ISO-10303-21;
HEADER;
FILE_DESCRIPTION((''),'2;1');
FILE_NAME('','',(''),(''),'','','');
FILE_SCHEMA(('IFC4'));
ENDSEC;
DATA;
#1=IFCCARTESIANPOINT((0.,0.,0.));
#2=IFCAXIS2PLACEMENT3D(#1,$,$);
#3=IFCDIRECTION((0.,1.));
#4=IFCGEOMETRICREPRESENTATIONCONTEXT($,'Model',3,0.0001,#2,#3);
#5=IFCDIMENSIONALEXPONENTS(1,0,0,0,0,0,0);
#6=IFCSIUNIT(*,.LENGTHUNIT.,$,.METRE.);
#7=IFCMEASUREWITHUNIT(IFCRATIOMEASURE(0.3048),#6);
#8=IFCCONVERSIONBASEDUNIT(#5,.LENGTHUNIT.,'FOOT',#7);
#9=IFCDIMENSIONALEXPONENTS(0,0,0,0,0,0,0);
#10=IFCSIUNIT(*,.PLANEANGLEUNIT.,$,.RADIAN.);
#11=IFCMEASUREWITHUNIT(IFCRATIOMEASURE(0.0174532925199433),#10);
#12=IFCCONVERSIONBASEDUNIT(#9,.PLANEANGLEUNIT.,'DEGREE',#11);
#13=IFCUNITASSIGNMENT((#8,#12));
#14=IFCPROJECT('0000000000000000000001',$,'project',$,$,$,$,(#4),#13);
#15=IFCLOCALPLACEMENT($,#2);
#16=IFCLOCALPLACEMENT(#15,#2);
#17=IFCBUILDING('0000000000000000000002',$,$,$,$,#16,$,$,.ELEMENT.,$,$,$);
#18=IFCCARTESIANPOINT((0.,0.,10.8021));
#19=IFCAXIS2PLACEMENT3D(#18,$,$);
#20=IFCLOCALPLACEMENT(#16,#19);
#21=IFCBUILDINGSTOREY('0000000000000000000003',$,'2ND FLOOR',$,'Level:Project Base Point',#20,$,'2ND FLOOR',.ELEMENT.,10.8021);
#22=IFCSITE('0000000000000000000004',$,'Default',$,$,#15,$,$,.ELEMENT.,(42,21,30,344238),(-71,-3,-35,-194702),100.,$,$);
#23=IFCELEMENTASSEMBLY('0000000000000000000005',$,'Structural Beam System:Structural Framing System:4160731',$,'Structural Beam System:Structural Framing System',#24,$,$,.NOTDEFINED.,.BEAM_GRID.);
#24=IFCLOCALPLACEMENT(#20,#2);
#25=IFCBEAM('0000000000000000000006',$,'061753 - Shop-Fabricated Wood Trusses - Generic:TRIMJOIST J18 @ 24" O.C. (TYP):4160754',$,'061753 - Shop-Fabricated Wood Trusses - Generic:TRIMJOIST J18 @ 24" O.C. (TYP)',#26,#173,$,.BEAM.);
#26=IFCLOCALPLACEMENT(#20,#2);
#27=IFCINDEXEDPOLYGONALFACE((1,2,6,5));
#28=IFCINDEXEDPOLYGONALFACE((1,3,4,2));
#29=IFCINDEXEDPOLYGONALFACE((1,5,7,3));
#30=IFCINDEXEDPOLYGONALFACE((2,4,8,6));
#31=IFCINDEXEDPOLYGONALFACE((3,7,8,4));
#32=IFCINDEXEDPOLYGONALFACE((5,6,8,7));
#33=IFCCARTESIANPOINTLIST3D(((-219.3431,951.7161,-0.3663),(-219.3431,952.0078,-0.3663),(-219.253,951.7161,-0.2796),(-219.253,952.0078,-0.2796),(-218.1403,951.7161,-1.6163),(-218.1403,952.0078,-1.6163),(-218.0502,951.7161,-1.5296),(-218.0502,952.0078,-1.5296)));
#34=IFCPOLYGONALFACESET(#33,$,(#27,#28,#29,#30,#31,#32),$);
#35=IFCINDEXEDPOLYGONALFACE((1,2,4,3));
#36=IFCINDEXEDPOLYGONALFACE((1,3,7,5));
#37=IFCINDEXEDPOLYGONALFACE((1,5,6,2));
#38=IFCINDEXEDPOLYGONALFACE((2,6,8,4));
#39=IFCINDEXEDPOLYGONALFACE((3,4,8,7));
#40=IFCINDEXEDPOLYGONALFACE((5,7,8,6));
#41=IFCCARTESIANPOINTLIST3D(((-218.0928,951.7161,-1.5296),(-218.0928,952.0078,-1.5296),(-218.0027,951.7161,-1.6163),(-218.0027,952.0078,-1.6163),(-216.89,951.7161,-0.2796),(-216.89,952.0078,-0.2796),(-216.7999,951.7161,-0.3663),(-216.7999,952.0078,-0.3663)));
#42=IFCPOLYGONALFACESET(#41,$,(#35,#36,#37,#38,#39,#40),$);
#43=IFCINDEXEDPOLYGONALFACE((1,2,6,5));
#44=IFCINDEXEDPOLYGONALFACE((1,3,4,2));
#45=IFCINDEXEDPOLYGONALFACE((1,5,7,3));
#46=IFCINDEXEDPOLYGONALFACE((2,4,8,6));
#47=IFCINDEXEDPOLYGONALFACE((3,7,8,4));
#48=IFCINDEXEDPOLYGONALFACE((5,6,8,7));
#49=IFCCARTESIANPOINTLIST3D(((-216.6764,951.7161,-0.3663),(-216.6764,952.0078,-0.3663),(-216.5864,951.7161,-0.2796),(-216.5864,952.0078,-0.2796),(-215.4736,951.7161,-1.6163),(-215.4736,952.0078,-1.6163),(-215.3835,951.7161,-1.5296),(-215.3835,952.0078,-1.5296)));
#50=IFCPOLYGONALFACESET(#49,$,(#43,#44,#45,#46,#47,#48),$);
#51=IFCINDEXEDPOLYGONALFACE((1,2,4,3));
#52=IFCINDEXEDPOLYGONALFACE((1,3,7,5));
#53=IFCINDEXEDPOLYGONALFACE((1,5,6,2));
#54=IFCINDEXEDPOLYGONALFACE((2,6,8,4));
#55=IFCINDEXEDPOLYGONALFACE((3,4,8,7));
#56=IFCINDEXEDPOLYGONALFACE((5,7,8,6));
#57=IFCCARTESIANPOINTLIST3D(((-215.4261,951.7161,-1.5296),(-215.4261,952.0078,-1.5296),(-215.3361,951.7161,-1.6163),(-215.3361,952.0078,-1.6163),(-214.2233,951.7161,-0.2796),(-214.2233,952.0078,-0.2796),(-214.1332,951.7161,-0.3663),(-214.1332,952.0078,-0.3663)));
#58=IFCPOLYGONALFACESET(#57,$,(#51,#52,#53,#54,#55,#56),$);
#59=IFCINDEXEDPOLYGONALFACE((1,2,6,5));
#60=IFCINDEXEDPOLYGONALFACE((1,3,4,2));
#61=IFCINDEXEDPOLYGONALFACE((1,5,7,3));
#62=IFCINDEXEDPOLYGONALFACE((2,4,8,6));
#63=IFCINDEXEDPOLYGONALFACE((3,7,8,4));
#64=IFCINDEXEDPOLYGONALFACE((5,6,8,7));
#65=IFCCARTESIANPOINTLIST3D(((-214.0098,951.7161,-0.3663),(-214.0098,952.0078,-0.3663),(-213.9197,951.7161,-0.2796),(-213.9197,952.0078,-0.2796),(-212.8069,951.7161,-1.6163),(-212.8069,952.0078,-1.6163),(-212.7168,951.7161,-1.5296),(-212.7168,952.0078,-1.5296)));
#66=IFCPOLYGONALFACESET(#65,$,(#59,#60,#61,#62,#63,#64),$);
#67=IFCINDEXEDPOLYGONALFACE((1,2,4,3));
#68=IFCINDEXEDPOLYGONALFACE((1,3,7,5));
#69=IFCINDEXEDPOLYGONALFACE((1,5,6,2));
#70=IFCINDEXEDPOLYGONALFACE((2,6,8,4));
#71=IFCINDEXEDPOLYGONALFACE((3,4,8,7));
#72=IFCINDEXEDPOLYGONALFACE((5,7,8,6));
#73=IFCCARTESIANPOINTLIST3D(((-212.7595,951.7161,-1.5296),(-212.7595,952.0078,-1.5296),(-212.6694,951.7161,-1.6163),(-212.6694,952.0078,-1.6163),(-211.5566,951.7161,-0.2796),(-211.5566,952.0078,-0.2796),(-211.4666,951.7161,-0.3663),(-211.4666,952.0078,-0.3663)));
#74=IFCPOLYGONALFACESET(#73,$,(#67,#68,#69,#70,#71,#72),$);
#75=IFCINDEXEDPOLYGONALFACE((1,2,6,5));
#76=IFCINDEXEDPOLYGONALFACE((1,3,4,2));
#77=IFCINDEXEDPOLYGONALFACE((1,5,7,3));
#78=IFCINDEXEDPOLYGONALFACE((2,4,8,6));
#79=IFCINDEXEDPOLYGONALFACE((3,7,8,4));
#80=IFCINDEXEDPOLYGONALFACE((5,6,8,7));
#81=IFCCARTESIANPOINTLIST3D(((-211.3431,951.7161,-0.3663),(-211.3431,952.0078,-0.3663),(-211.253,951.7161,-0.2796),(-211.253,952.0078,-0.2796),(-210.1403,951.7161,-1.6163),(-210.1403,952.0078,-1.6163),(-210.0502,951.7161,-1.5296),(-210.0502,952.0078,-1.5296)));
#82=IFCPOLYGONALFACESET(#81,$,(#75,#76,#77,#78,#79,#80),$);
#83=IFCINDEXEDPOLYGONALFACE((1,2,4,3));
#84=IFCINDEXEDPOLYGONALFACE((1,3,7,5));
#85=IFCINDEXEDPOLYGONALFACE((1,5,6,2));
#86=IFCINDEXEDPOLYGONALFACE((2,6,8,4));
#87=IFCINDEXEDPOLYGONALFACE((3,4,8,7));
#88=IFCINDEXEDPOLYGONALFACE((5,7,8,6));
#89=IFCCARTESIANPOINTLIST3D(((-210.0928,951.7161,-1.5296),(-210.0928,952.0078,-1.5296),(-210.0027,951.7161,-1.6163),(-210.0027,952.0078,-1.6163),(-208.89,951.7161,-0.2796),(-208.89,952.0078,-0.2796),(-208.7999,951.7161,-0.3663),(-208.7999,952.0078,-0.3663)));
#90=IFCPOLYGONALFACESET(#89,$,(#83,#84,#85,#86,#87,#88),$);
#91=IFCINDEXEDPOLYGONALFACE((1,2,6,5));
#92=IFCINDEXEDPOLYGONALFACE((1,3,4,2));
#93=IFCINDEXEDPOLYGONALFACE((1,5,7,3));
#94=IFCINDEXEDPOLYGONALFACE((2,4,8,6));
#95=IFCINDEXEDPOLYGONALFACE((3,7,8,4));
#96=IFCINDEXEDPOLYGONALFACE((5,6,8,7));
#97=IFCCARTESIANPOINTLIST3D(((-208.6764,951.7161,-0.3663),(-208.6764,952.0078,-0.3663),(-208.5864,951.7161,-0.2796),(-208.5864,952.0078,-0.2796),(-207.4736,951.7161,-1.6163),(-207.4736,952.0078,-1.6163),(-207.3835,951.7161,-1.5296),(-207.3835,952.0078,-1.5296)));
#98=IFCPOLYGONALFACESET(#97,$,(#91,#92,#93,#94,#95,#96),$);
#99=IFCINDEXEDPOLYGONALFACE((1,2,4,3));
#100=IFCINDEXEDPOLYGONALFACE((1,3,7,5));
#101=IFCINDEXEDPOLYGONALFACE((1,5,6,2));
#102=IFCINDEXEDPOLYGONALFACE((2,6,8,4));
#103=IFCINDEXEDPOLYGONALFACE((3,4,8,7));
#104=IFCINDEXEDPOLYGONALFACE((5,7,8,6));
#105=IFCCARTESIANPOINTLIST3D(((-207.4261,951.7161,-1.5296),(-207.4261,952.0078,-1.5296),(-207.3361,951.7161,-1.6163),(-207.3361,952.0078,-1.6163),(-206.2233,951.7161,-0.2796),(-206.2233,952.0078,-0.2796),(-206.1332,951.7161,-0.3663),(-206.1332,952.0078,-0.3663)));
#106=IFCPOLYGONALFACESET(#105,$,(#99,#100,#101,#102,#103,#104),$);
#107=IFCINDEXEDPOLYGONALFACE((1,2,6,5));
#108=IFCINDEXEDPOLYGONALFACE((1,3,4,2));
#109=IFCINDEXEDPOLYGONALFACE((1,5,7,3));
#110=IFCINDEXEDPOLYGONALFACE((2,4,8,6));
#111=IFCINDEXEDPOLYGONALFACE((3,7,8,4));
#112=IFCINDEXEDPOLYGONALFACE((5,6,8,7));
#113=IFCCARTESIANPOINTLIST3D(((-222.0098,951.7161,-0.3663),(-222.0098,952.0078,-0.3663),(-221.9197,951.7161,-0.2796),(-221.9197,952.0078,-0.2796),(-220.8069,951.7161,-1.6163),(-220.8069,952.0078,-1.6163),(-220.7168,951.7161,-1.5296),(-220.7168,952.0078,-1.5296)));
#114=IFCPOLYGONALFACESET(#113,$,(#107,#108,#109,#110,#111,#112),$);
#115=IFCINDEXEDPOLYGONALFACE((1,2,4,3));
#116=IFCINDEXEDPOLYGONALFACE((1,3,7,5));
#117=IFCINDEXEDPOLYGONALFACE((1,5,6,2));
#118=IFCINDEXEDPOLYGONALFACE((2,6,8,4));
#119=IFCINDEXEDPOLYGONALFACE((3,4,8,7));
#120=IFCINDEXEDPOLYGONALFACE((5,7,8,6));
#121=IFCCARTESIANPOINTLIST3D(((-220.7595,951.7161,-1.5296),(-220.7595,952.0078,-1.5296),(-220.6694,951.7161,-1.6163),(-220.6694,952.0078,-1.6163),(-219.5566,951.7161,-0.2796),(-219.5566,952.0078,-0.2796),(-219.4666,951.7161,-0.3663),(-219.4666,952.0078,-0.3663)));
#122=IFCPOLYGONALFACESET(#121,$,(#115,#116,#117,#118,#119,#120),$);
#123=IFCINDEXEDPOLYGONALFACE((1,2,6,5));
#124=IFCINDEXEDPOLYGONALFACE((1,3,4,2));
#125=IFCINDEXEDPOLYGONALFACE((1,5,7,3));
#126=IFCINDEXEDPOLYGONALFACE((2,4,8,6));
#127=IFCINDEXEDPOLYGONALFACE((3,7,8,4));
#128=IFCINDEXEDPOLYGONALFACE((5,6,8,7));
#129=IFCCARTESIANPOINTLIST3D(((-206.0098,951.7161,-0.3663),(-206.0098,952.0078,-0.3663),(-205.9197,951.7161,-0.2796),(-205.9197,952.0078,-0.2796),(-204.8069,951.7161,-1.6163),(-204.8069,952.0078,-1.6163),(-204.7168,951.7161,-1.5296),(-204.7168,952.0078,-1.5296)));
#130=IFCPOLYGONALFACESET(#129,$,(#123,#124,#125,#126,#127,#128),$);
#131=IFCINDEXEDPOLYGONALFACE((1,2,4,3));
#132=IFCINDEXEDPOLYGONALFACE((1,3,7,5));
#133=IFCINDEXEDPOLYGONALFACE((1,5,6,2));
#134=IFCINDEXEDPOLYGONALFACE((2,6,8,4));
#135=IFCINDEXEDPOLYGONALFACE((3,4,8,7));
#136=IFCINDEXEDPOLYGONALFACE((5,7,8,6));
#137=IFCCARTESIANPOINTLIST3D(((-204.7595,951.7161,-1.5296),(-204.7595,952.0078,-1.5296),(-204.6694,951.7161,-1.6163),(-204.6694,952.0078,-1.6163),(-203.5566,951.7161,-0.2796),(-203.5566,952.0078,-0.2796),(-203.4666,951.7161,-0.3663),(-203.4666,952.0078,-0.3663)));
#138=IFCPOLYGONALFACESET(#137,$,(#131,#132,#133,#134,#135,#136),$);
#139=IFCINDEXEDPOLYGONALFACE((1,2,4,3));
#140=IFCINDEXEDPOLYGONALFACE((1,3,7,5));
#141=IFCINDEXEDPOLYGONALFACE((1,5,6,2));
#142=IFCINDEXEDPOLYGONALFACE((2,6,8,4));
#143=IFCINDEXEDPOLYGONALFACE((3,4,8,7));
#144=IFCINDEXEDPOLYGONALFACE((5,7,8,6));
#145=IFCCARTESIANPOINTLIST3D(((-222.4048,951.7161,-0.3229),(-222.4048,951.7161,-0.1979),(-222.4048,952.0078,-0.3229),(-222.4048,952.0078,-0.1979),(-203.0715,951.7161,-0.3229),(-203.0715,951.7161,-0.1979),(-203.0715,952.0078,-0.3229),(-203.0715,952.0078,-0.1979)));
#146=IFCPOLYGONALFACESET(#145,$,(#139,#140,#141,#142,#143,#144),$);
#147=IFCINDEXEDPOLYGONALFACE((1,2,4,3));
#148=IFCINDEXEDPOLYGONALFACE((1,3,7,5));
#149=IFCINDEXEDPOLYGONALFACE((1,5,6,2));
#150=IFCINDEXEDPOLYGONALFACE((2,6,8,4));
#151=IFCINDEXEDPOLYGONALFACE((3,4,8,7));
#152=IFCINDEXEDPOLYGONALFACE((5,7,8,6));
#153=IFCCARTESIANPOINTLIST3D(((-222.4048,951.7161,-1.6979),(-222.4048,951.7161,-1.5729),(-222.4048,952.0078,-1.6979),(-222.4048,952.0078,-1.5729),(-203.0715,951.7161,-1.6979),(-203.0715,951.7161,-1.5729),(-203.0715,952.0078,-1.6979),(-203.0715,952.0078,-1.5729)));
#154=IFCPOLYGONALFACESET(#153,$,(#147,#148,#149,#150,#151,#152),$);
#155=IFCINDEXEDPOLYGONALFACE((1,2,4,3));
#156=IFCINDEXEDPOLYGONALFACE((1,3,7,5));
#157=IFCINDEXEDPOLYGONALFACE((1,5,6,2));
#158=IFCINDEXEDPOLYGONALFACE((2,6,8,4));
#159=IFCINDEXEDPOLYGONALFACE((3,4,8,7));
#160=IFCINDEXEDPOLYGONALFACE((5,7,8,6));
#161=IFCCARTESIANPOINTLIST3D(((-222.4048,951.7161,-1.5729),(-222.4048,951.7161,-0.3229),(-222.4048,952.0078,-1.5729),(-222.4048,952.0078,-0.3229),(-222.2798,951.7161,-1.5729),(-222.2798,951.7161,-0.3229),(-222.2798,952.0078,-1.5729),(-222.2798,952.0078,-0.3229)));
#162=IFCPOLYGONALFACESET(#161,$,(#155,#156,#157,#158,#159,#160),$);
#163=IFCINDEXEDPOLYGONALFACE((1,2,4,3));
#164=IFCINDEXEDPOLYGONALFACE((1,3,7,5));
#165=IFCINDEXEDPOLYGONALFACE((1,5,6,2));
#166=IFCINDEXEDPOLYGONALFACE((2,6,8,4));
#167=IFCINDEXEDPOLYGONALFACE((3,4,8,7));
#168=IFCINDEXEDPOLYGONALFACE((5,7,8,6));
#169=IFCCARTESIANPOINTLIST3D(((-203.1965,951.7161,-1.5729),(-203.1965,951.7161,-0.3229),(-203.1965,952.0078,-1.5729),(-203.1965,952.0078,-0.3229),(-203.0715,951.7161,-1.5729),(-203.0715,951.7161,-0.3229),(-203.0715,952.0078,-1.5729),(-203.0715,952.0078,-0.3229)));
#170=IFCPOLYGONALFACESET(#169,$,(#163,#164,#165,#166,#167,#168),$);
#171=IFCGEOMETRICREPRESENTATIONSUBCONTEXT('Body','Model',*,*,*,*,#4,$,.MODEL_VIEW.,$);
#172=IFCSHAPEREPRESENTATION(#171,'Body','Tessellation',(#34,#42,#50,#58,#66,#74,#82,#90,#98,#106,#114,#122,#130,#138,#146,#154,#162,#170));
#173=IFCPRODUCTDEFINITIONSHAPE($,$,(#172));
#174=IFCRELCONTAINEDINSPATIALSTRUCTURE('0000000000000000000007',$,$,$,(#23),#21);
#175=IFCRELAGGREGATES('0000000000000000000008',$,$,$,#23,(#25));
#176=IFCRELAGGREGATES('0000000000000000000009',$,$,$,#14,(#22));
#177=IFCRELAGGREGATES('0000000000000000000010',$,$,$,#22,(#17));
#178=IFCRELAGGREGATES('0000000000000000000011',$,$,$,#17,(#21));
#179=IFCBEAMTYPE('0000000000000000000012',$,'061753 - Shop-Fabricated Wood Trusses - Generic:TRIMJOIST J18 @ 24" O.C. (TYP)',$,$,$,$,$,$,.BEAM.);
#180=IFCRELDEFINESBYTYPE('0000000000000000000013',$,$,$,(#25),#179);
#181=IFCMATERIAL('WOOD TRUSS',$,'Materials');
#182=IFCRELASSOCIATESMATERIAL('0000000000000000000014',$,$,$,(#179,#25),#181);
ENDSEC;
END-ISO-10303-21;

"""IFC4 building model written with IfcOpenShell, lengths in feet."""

from ifc_helpers import new_model, entity, si_unit, converted_unit, direction, frame, frame_2d, origin, origin_2d_with_axis, place, context, subcontext, project, spatial, rectangle, extrude, source, transform, mapped, material, material_profile, profile_set, profile_usage, type_object, type_shapes, element, aggregate, save


model = new_model("IFC4")

# Units and contexts
model_context = context("Model", 3, precision=0.0001, world=origin(), true_north=direction((0.0, 1.0)))
body_context = subcontext(model_context, "Body", "Model", "MODEL_VIEW")
ifc_project = project(units=[converted_unit("LENGTHUNIT", "FOOT", entity("IfcRatioMeasure", 0.3048), si_unit("LENGTHUNIT", "METRE"), dimensions=[1, 0, 0, 0, 0, 0, 0]), converted_unit("PLANEANGLEUNIT", "DEGREE", entity("IfcRatioMeasure", 0.0174532925199433), si_unit("PLANEANGLEUNIT", "RADIAN"), dimensions=[0, 0, 0, 0, 0, 0, 0])], contexts=[model_context])

# Site, building, storey
site_placement = place(None, origin())
site = spatial("IfcSite", under=ifc_project, at=site_placement, Name="Default", CompositionType="ELEMENT", RefLatitude=(42, 21, 30, 344238), RefLongitude=(-71, -3, -35, -194702), RefElevation=100.0)
building_placement = place(site_placement, origin())
building = spatial("IfcBuilding", under=site, at=building_placement, CompositionType="ELEMENT")
storey_placement = place(building_placement, frame((0.0, 0.0, 10.8021)))
storey = spatial("IfcBuildingStorey", under=building, at=storey_placement, Name="2ND FLOOR", ObjectType="Level:Project Base Point", LongName="2ND FLOOR", CompositionType="ELEMENT", Elevation=10.8021)

# Element assembly, beam
ifc_material_1 = material(Name="WOOD TRUSS", Category="Materials")
ifc_material_profile_1 = material_profile(ifc_material_1, rectangle(XDim=1.7347, YDim=0.125, at=frame_2d((0.0, 0.0), x_axis=(1.0, 0.0))), Name="TRIMJOIST J18 @ 24\" O.C. (TYP)")
ifc_material_profile_2 = material_profile(ifc_material_1, rectangle(XDim=1.7347, YDim=0.125, at=frame_2d((0.0, 0.0), x_axis=(1.0, 0.0))), Name="TRIMJOIST J18 @ 24\" O.C. (TYP)")
ifc_material_profile_3 = material_profile(ifc_material_1, rectangle(XDim=1.7347, YDim=0.125, at=frame_2d((0.0, 0.0), x_axis=(1.0, 0.0))), Name="TRIMJOIST J18 @ 24\" O.C. (TYP)")
ifc_material_profile_4 = material_profile(ifc_material_1, rectangle(XDim=1.7347, YDim=0.125, at=frame_2d((0.0, 0.0), x_axis=(1.0, 0.0))), Name="TRIMJOIST J18 @ 24\" O.C. (TYP)")
ifc_material_profile_5 = material_profile(ifc_material_1, rectangle(XDim=1.7347, YDim=0.125, at=frame_2d((0.0, 0.0), x_axis=(1.0, 0.0))), Name="TRIMJOIST J18 @ 24\" O.C. (TYP)")
ifc_material_profile_6 = material_profile(ifc_material_1, rectangle(XDim=1.7347, YDim=0.125, at=frame_2d((0.0, 0.0), x_axis=(1.0, 0.0))), Name="TRIMJOIST J18 @ 24\" O.C. (TYP)")
ifc_material_profile_7 = material_profile(ifc_material_1, rectangle(XDim=1.7347, YDim=0.125, at=frame_2d((0.0, 0.0), x_axis=(1.0, 0.0))), Name="TRIMJOIST J18 @ 24\" O.C. (TYP)")
ifc_material_profile_8 = material_profile(ifc_material_1, rectangle(XDim=1.7347, YDim=0.125, at=frame_2d((0.0, 0.0), x_axis=(1.0, 0.0))), Name="TRIMJOIST J18 @ 24\" O.C. (TYP)")
ifc_material_profile_9 = material_profile(ifc_material_1, rectangle(XDim=1.7347, YDim=0.125, at=frame_2d((0.0, 0.0), x_axis=(1.0, 0.0))), Name="TRIMJOIST J18 @ 24\" O.C. (TYP)")
ifc_material_profile_10 = material_profile(ifc_material_1, rectangle(XDim=1.7347, YDim=0.125, at=origin_2d_with_axis()), Name="TRIMJOIST J18 @ 24\" O.C. (TYP)")
ifc_material_profile_11 = material_profile(ifc_material_1, rectangle(XDim=0.125, YDim=0.2917, at=origin_2d_with_axis()), Name="TRIMJOIST J18 @ 24\" O.C. (TYP)")
ifc_material_profile_12 = material_profile(ifc_material_1, rectangle(XDim=0.125, YDim=0.2917, at=origin_2d_with_axis()), Name="TRIMJOIST J18 @ 24\" O.C. (TYP)")
ifc_material_profile_13 = material_profile(ifc_material_1, rectangle(XDim=1.25, YDim=0.2917, at=origin_2d_with_axis()), Name="TRIMJOIST J18 @ 24\" O.C. (TYP)")
ifc_material_profile_14 = material_profile(ifc_material_1, rectangle(XDim=1.25, YDim=0.2917, at=origin_2d_with_axis()), Name="TRIMJOIST J18 @ 24\" O.C. (TYP)")
ifc_profile_set_1 = profile_set([ifc_material_profile_1, ifc_material_profile_2, ifc_material_profile_3, ifc_material_profile_4, ifc_material_profile_5, ifc_material_profile_6, ifc_material_profile_7, ifc_material_profile_8, ifc_material_profile_9, ifc_material_profile_10, ifc_material_profile_11, ifc_material_profile_12, ifc_material_profile_13, ifc_material_profile_14], Name="TRIMJOIST J18 @ 24\" O.C. (TYP)")
beam_type_1 = type_object("IfcBeamType", Name="061753 - Shop-Fabricated Wood Trusses - Generic:TRIMJOIST J18 @ 24\" O.C. (TYP)", PredefinedType="BEAM", material=ifc_profile_set_1)
shared_shape_1 = source(origin(), body_context, "Body", "SweptSolid", [
    extrude(rectangle(XDim=1.7347, YDim=0.125, at=frame_2d((0.0, 0.0), x_axis=(1.0, 0.0))), frame((5.9585, -0.1458, 0.0), z_axis=(0.0, 1.0, 0.0), x_axis=(0.693383, 0.0, 0.720569)), (0.0, 0.0, 1.0), 0.2917),
    extrude(rectangle(XDim=1.7347, YDim=0.125, at=origin_2d_with_axis()), frame((4.7082, -0.1458, 0.0), z_axis=(0.0, 1.0, 0.0), x_axis=(0.693383, 0.0, -0.720569)), (0.0, 0.0, 1.0), 0.2917),
    extrude(rectangle(XDim=1.7347, YDim=0.125, at=frame_2d((0.0, 0.0), x_axis=(1.0, 0.0))), frame((3.2918, -0.1458, 0.0), z_axis=(0.0, 1.0, 0.0), x_axis=(0.693383, 0.0, 0.720569)), (0.0, 0.0, 1.0), 0.2917),
    extrude(rectangle(XDim=1.7347, YDim=0.125, at=frame_2d((0.0, 0.0), x_axis=(1.0, 0.0))), frame((2.0415, -0.1458, 0.0), z_axis=(0.0, 1.0, 0.0), x_axis=(0.693383, 0.0, -0.720569)), (0.0, 0.0, 1.0), 0.2917),
    extrude(rectangle(XDim=1.7347, YDim=0.125, at=frame_2d((0.0, 0.0), x_axis=(1.0, 0.0))), frame((0.6251, -0.1458, 0.0), z_axis=(0.0, 1.0, 0.0), x_axis=(0.693383, 0.0, 0.720569)), (0.0, 0.0, 1.0), 0.2917),
    extrude(rectangle(XDim=1.7347, YDim=0.125, at=frame_2d((0.0, 0.0), x_axis=(1.0, 0.0))), frame((-0.6251, -0.1458, 0.0), z_axis=(0.0, 1.0, 0.0), x_axis=(0.693383, 0.0, -0.720569)), (0.0, 0.0, 1.0), 0.2917),
    extrude(rectangle(XDim=1.7347, YDim=0.125, at=frame_2d((0.0, 0.0), x_axis=(1.0, 0.0))), frame((-2.0415, -0.1458, 0.0), z_axis=(0.0, 1.0, 0.0), x_axis=(0.693383, 0.0, 0.720569)), (0.0, 0.0, 1.0), 0.2917),
    extrude(rectangle(XDim=1.7347, YDim=0.125, at=origin_2d_with_axis()), frame((-3.2918, -0.1458, 0.0), z_axis=(0.0, 1.0, 0.0), x_axis=(0.693383, 0.0, -0.720569)), (0.0, 0.0, 1.0), 0.2917),
    extrude(rectangle(XDim=1.7347, YDim=0.125, at=frame_2d((0.0, 0.0), x_axis=(1.0, 0.0))), frame((-4.7082, -0.1458, 0.0), z_axis=(0.0, 1.0, 0.0), x_axis=(0.693383, 0.0, 0.720569)), (0.0, 0.0, 1.0), 0.2917),
    extrude(rectangle(XDim=1.7347, YDim=0.125, at=frame_2d((0.0, 0.0), x_axis=(1.0, 0.0))), frame((-5.9585, -0.1458, 0.0), z_axis=(0.0, 1.0, 0.0), x_axis=(0.693383, 0.0, -0.720569)), (0.0, 0.0, 1.0), 0.2917),
    extrude(rectangle(XDim=1.7347, YDim=0.125, at=frame_2d((0.0, 0.0), x_axis=(1.0, 0.0))), frame((8.6251, -0.1458, 0.0), z_axis=(0.0, 1.0, 0.0), x_axis=(0.693383, 0.0, 0.720569)), (0.0, 0.0, 1.0), 0.2917),
    extrude(rectangle(XDim=1.7347, YDim=0.125, at=origin_2d_with_axis()), frame((7.3749, -0.1458, 0.0), z_axis=(0.0, 1.0, 0.0), x_axis=(0.693383, 0.0, -0.720569)), (0.0, 0.0, 1.0), 0.2917),
    extrude(rectangle(XDim=1.7347, YDim=0.125, at=frame_2d((0.0, 0.0), x_axis=(1.0, 0.0))), frame((-7.3749, -0.1458, 0.0), z_axis=(0.0, 1.0, 0.0), x_axis=(0.693383, 0.0, 0.720569)), (0.0, 0.0, 1.0), 0.2917),
    extrude(rectangle(XDim=1.7347, YDim=0.125, at=origin_2d_with_axis()), frame((-8.6251, -0.1458, 0.0), z_axis=(0.0, 1.0, 0.0), x_axis=(0.693383, 0.0, -0.720569)), (0.0, 0.0, 1.0), 0.2917),
    extrude(rectangle(XDim=0.125, YDim=0.2917, at=origin_2d_with_axis()), frame((-9.6667, 0.0, 0.6875), z_axis=(1.0, 0.0, 0.0), x_axis=(0.0, 0.0, -1.0)), (0.0, 0.0, 1.0), 19.3333),
    extrude(rectangle(XDim=0.125, YDim=0.2917, at=origin_2d_with_axis()), frame((-9.6667, 0.0, -0.6875), z_axis=(1.0, 0.0, 0.0), x_axis=(0.0, 0.0, -1.0)), (0.0, 0.0, 1.0), 19.3333),
    extrude(rectangle(XDim=1.25, YDim=0.2917, at=origin_2d_with_axis()), frame((9.5417, 0.0, 0.0), z_axis=(1.0, 0.0, 0.0), x_axis=(0.0, 0.0, -1.0)), (0.0, 0.0, 1.0), 0.125),
    extrude(rectangle(XDim=1.25, YDim=0.2917, at=origin_2d_with_axis()), frame((-9.6667, 0.0, 0.0), z_axis=(1.0, 0.0, 0.0), x_axis=(0.0, 0.0, -1.0)), (0.0, 0.0, 1.0), 0.125),
])
type_shapes(beam_type_1, [shared_shape_1])
assembly_1_placement = place(storey_placement, origin())
assembly_1 = element("IfcElementAssembly", 1, at=assembly_1_placement, inside=storey, Name="Structural Beam System:Structural Framing System:4160731", ObjectType="Structural Beam System:Structural Framing System", AssemblyPlace="NOTDEFINED", PredefinedType="BEAM_GRID")
ifc_profile_usage_1 = profile_usage(ifc_profile_set_1, cardinal=8)
beam_1_placement = place(assembly_1_placement, frame((-212.7382, 951.8619, -0.9479), z_axis=(0.0, 0.0, 1.0), x_axis=(-1.0, 0.0, 0.0)))
beam_1 = element("IfcBeam", 2, at=beam_1_placement, type_object=beam_type_1, material=ifc_profile_usage_1, Name="061753 - Shop-Fabricated Wood Trusses - Generic:TRIMJOIST J18 @ 24\" O.C. (TYP):4160754", ObjectType="061753 - Shop-Fabricated Wood Trusses - Generic:TRIMJOIST J18 @ 24\" O.C. (TYP)", PredefinedType="BEAM", context=body_context, shape_type="MappedRepresentation", body=[
    mapped(shared_shape_1, transform((0.0, 0.0, 0.0), scale=1.0)),
])
aggregate(assembly_1, [beam_1])

save(model, "model.ifc")
